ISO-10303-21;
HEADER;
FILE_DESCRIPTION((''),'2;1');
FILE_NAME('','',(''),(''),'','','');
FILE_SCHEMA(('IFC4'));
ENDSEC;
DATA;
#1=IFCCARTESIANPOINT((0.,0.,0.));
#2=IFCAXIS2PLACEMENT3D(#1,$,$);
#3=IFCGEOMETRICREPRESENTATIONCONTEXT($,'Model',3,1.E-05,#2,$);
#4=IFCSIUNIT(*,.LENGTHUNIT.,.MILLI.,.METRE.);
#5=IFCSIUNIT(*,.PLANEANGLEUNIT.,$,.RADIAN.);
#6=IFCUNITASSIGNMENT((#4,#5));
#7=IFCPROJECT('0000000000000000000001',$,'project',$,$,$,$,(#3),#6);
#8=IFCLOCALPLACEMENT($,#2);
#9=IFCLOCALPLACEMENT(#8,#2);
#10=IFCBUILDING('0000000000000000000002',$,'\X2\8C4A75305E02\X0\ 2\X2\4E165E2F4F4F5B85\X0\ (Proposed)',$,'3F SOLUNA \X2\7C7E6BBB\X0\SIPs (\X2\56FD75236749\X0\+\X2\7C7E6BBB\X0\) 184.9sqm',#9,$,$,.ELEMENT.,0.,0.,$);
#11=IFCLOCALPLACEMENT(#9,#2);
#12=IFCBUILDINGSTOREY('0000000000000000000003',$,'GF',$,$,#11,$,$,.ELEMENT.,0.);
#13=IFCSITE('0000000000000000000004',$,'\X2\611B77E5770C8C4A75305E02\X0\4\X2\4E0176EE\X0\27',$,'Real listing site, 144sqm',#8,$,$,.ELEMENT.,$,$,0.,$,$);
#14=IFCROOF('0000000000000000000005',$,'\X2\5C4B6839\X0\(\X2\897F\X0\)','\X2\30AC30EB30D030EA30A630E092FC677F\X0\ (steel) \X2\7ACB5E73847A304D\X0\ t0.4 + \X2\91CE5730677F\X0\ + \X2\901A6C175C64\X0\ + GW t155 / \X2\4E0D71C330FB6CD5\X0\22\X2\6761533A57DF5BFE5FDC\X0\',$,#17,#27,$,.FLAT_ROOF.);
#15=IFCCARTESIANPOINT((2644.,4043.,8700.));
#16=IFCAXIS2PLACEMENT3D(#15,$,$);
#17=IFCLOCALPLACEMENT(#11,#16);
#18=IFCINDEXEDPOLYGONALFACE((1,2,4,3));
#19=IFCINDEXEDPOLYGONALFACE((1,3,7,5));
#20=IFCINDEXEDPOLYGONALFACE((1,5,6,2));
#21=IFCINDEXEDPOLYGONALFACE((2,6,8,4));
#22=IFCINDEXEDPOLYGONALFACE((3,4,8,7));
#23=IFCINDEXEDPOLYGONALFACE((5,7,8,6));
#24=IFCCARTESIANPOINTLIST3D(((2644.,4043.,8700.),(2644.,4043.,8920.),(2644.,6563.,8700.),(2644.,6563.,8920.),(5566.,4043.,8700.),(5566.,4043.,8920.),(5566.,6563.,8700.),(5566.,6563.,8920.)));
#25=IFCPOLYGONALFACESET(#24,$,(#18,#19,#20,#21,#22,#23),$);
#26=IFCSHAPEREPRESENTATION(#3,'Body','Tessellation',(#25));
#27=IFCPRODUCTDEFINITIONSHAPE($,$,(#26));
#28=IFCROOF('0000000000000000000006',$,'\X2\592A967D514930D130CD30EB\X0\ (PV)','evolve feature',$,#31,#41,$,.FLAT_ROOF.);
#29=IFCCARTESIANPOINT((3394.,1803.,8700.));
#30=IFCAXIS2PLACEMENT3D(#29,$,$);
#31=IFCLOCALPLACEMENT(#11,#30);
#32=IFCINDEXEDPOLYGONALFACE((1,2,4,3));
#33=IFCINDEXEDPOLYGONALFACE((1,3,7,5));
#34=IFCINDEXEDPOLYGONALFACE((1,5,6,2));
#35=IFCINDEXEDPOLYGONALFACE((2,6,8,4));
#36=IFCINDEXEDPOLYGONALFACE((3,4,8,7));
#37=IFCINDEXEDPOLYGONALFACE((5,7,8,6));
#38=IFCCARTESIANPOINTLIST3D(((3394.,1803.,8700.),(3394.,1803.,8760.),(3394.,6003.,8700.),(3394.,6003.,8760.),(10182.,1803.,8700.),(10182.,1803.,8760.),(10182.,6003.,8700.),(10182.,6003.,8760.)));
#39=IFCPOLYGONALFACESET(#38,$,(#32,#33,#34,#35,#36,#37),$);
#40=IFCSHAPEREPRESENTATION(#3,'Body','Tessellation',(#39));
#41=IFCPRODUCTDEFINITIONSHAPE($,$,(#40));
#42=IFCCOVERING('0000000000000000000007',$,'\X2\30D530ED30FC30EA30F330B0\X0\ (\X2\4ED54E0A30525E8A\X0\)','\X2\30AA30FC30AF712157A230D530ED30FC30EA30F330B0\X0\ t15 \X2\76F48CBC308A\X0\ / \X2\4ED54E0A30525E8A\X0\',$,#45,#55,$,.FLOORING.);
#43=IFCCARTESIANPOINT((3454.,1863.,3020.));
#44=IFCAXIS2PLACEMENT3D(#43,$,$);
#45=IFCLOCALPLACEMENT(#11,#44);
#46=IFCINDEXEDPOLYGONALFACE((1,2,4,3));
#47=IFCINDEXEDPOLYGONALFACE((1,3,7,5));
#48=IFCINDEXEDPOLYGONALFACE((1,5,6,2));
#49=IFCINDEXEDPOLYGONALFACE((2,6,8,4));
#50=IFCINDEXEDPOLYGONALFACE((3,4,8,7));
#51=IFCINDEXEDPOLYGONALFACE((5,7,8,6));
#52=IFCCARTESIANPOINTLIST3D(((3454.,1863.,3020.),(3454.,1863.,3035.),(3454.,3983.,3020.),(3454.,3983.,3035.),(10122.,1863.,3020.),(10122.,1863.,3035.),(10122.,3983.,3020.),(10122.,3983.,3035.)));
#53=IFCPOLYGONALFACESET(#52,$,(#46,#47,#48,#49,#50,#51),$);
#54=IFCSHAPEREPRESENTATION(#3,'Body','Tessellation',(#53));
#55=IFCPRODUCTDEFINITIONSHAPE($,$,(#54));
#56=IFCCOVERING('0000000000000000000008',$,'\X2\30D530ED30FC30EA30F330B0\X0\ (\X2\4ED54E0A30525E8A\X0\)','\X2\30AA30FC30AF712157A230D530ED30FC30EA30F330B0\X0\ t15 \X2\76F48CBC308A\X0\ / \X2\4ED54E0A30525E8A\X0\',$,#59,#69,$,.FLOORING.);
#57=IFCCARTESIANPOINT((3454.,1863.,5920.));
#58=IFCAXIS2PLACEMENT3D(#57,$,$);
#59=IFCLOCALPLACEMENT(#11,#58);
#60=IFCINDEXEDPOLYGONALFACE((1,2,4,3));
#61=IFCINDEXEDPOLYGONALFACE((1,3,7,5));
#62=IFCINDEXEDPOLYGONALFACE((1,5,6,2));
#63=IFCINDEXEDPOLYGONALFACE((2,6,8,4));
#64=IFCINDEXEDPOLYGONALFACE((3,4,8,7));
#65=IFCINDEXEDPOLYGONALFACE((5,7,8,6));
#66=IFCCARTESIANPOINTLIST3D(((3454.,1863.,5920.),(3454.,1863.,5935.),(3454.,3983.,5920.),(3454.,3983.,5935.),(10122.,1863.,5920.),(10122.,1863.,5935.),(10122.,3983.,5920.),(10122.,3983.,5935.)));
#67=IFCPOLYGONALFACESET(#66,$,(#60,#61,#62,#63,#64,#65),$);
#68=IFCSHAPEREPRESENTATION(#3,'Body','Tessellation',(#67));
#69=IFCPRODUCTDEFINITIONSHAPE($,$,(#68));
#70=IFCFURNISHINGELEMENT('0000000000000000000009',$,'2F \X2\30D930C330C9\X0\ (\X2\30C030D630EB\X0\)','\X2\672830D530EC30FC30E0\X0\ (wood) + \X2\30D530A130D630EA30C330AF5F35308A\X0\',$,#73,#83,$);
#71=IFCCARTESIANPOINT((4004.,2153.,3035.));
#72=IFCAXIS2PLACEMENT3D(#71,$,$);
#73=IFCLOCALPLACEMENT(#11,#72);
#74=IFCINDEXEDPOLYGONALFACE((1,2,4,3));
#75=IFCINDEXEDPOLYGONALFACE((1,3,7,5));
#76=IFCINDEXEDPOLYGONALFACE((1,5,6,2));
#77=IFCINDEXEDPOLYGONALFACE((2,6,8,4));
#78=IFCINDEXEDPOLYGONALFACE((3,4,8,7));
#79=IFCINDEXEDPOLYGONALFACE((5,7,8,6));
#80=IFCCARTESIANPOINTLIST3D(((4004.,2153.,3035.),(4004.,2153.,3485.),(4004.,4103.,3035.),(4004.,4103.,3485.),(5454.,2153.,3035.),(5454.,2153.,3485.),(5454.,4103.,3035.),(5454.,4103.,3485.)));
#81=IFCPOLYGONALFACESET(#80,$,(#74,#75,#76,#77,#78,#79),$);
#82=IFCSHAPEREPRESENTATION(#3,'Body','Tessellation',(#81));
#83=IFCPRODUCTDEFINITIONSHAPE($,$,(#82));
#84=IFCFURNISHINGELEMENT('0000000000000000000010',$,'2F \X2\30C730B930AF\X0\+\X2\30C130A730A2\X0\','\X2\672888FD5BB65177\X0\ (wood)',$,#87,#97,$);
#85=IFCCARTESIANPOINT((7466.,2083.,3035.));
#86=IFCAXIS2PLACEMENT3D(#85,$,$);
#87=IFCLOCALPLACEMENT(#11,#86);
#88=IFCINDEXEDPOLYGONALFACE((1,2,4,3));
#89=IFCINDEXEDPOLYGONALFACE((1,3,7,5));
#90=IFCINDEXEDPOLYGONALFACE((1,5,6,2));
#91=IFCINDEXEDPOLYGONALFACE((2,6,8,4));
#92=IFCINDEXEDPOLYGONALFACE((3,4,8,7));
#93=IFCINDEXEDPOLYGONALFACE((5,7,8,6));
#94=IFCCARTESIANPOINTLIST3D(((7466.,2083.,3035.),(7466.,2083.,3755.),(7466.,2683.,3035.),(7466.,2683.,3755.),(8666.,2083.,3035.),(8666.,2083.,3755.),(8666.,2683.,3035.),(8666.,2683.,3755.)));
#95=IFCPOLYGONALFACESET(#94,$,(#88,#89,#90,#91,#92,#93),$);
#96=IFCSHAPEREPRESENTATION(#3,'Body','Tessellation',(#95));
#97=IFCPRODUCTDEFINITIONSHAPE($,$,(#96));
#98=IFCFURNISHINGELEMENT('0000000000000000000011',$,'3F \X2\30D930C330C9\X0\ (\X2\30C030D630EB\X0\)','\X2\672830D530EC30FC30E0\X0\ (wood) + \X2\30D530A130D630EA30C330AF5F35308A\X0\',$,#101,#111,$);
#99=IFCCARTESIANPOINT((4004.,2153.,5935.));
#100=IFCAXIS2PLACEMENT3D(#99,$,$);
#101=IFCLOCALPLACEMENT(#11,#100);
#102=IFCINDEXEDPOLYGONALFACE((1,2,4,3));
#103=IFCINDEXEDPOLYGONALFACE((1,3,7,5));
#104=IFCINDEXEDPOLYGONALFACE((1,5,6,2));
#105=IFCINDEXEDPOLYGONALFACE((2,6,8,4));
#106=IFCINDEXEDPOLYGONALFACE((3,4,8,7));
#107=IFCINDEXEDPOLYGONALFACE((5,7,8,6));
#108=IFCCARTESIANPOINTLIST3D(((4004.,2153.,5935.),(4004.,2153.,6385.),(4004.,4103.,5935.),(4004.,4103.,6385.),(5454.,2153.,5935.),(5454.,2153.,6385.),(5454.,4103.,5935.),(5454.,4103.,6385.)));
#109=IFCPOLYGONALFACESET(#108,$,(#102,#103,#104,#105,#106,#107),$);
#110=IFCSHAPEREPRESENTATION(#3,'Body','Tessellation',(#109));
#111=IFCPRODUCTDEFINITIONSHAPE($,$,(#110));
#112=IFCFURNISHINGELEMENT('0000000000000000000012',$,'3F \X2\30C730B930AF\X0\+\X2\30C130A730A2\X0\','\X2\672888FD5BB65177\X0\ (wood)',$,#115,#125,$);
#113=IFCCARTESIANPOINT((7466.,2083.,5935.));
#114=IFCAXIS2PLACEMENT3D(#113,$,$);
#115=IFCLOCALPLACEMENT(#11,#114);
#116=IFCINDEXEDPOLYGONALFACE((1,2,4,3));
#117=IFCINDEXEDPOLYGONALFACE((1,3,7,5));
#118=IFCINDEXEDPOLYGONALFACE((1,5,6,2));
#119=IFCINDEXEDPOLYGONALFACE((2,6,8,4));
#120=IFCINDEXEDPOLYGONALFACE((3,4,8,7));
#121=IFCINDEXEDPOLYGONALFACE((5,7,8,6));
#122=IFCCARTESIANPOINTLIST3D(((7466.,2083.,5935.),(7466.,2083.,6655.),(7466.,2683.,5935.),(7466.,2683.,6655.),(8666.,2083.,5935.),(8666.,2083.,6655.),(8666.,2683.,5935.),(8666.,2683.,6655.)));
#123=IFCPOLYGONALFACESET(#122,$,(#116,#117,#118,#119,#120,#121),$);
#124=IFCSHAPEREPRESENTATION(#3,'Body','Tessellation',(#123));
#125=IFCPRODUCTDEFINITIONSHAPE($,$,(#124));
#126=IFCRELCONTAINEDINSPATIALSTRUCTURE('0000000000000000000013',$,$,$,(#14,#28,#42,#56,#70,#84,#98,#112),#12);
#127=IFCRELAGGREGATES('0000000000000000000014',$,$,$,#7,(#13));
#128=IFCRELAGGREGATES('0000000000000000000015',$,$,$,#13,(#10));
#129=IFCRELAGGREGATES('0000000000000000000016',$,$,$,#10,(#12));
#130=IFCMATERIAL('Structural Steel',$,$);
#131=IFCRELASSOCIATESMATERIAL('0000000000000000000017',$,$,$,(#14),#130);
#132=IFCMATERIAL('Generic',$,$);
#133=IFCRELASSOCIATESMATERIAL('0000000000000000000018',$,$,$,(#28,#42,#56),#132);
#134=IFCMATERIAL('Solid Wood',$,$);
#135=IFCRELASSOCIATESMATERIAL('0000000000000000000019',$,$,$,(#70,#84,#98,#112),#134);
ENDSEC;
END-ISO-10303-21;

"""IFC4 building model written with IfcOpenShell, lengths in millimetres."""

from ifc_helpers import new_model, si_unit, frame, frame_2d, origin, place, context, project, spatial, rectangle, extrude, material, element, save


model = new_model("IFC4")

# Units and contexts
model_context = context("Model", 3, precision=1e-05, world=origin())
ifc_project = project(units=[si_unit("LENGTHUNIT", "METRE", prefix="MILLI"), si_unit("PLANEANGLEUNIT", "RADIAN")], contexts=[model_context])

# Site, building, storey
site_placement = place(None, origin())
site = spatial("IfcSite", under=ifc_project, at=site_placement, Name="愛知県豊田市4丁目27", ObjectType="Real listing site, 144sqm", CompositionType="ELEMENT", RefElevation=0.0)
building_placement = place(site_placement, origin())
building = spatial("IfcBuilding", under=site, at=building_placement, Name="豊田市 2世帯住宅 (Proposed)", ObjectType="3F SOLUNA 籾殻SIPs (国産杉+籾殻) 184.9sqm", CompositionType="ELEMENT", ElevationOfRefHeight=0.0, ElevationOfTerrain=0.0)
storey_placement = place(building_placement, origin())
storey = spatial("IfcBuildingStorey", under=building, at=storey_placement, Name="GF", CompositionType="ELEMENT", Elevation=0.0)

# Shared definitions
ifc_material_1 = material(Name="Solid Wood")

# Roofs
ifc_material_2 = material(Name="Structural Steel")
roof_1_placement = place(storey_placement, frame((2644.0, 4043.0, 8700.0)))
element("IfcRoof", 1, at=roof_1_placement, inside=storey, material=ifc_material_2, Name="屋根(西)", Description="ガルバリウム鋼板 (steel) 立平葺き t0.4 + 野地板 + 通気層 + GW t155 / 不燃・法22条区域対応", PredefinedType="FLAT_ROOF", context=model_context, shape_type="SweptSolid", body=[
    extrude(rectangle(XDim=2922.0, YDim=2520.0, at=frame_2d((1461.0, 1260.0))), frame((2644.0, 4043.0, 8700.0)), (0.0, 0.0, 1.0), 220.0),
])
ifc_material_3 = material(Name="Generic")
roof_2_placement = place(storey_placement, frame((3394.0, 1803.0, 8700.0)))
element("IfcRoof", 2, at=roof_2_placement, inside=storey, material=ifc_material_3, Name="太陽光パネル (PV)", Description="evolve feature", PredefinedType="FLAT_ROOF", context=model_context, shape_type="SweptSolid", body=[
    extrude(rectangle(XDim=6788.0, YDim=4200.0, at=frame_2d((3394.0, 2100.0))), frame((3394.0, 1803.0, 8700.0)), (0.0, 0.0, 1.0), 60.0),
])

# Coverings
covering_1_placement = place(storey_placement, frame((3454.0, 1863.0, 3020.0)))
element("IfcCovering", 3, at=covering_1_placement, inside=storey, material=ifc_material_3, Name="フローリング (仕上げ床)", Description="オーク無垢フローリング t15 直貼り / 仕上げ床", PredefinedType="FLOORING", context=model_context, shape_type="SweptSolid", body=[
    extrude(rectangle(XDim=6668.0, YDim=2120.0, at=frame_2d((3334.0, 1060.0))), frame((3454.0, 1863.0, 3020.0)), (0.0, 0.0, 1.0), 15.0),
])
covering_2_placement = place(storey_placement, frame((3454.0, 1863.0, 5920.0)))
element("IfcCovering", 4, at=covering_2_placement, inside=storey, material=ifc_material_3, Name="フローリング (仕上げ床)", Description="オーク無垢フローリング t15 直貼り / 仕上げ床", PredefinedType="FLOORING", context=model_context, shape_type="SweptSolid", body=[
    extrude(rectangle(XDim=6668.0, YDim=2120.0, at=frame_2d((3334.0, 1060.0))), frame((3454.0, 1863.0, 5920.0)), (0.0, 0.0, 1.0), 15.0),
])

# Furnishing elements
furnishing_1_placement = place(storey_placement, frame((4004.0, 2153.0, 3035.0)))
element("IfcFurnishingElement", 5, at=furnishing_1_placement, inside=storey, material=ifc_material_1, Name="2F ベッド (ダブル)", Description="木フレーム (wood) + ファブリック張り", context=model_context, shape_type="SweptSolid", body=[
    extrude(rectangle(XDim=1450.0, YDim=1950.0, at=frame_2d((725.0, 975.0))), frame((4004.0, 2153.0, 3035.0)), (0.0, 0.0, 1.0), 450.0),
])
furnishing_2_placement = place(storey_placement, frame((7466.0, 2083.0, 3035.0)))
element("IfcFurnishingElement", 6, at=furnishing_2_placement, inside=storey, material=ifc_material_1, Name="2F デスク+チェア", Description="木製家具 (wood)", context=model_context, shape_type="SweptSolid", body=[
    extrude(rectangle(XDim=1200.0, YDim=600.0, at=frame_2d((600.0, 300.0))), frame((7466.0, 2083.0, 3035.0)), (0.0, 0.0, 1.0), 720.0),
])
furnishing_3_placement = place(storey_placement, frame((4004.0, 2153.0, 5935.0)))
element("IfcFurnishingElement", 7, at=furnishing_3_placement, inside=storey, material=ifc_material_1, Name="3F ベッド (ダブル)", Description="木フレーム (wood) + ファブリック張り", context=model_context, shape_type="SweptSolid", body=[
    extrude(rectangle(XDim=1450.0, YDim=1950.0, at=frame_2d((725.0, 975.0))), frame((4004.0, 2153.0, 5935.0)), (0.0, 0.0, 1.0), 450.0),
])
furnishing_4_placement = place(storey_placement, frame((7466.0, 2083.0, 5935.0)))
element("IfcFurnishingElement", 8, at=furnishing_4_placement, inside=storey, material=ifc_material_1, Name="3F デスク+チェア", Description="木製家具 (wood)", context=model_context, shape_type="SweptSolid", body=[
    extrude(rectangle(XDim=1200.0, YDim=600.0, at=frame_2d((600.0, 300.0))), frame((7466.0, 2083.0, 5935.0)), (0.0, 0.0, 1.0), 720.0),
])

save(model, "model.ifc")
